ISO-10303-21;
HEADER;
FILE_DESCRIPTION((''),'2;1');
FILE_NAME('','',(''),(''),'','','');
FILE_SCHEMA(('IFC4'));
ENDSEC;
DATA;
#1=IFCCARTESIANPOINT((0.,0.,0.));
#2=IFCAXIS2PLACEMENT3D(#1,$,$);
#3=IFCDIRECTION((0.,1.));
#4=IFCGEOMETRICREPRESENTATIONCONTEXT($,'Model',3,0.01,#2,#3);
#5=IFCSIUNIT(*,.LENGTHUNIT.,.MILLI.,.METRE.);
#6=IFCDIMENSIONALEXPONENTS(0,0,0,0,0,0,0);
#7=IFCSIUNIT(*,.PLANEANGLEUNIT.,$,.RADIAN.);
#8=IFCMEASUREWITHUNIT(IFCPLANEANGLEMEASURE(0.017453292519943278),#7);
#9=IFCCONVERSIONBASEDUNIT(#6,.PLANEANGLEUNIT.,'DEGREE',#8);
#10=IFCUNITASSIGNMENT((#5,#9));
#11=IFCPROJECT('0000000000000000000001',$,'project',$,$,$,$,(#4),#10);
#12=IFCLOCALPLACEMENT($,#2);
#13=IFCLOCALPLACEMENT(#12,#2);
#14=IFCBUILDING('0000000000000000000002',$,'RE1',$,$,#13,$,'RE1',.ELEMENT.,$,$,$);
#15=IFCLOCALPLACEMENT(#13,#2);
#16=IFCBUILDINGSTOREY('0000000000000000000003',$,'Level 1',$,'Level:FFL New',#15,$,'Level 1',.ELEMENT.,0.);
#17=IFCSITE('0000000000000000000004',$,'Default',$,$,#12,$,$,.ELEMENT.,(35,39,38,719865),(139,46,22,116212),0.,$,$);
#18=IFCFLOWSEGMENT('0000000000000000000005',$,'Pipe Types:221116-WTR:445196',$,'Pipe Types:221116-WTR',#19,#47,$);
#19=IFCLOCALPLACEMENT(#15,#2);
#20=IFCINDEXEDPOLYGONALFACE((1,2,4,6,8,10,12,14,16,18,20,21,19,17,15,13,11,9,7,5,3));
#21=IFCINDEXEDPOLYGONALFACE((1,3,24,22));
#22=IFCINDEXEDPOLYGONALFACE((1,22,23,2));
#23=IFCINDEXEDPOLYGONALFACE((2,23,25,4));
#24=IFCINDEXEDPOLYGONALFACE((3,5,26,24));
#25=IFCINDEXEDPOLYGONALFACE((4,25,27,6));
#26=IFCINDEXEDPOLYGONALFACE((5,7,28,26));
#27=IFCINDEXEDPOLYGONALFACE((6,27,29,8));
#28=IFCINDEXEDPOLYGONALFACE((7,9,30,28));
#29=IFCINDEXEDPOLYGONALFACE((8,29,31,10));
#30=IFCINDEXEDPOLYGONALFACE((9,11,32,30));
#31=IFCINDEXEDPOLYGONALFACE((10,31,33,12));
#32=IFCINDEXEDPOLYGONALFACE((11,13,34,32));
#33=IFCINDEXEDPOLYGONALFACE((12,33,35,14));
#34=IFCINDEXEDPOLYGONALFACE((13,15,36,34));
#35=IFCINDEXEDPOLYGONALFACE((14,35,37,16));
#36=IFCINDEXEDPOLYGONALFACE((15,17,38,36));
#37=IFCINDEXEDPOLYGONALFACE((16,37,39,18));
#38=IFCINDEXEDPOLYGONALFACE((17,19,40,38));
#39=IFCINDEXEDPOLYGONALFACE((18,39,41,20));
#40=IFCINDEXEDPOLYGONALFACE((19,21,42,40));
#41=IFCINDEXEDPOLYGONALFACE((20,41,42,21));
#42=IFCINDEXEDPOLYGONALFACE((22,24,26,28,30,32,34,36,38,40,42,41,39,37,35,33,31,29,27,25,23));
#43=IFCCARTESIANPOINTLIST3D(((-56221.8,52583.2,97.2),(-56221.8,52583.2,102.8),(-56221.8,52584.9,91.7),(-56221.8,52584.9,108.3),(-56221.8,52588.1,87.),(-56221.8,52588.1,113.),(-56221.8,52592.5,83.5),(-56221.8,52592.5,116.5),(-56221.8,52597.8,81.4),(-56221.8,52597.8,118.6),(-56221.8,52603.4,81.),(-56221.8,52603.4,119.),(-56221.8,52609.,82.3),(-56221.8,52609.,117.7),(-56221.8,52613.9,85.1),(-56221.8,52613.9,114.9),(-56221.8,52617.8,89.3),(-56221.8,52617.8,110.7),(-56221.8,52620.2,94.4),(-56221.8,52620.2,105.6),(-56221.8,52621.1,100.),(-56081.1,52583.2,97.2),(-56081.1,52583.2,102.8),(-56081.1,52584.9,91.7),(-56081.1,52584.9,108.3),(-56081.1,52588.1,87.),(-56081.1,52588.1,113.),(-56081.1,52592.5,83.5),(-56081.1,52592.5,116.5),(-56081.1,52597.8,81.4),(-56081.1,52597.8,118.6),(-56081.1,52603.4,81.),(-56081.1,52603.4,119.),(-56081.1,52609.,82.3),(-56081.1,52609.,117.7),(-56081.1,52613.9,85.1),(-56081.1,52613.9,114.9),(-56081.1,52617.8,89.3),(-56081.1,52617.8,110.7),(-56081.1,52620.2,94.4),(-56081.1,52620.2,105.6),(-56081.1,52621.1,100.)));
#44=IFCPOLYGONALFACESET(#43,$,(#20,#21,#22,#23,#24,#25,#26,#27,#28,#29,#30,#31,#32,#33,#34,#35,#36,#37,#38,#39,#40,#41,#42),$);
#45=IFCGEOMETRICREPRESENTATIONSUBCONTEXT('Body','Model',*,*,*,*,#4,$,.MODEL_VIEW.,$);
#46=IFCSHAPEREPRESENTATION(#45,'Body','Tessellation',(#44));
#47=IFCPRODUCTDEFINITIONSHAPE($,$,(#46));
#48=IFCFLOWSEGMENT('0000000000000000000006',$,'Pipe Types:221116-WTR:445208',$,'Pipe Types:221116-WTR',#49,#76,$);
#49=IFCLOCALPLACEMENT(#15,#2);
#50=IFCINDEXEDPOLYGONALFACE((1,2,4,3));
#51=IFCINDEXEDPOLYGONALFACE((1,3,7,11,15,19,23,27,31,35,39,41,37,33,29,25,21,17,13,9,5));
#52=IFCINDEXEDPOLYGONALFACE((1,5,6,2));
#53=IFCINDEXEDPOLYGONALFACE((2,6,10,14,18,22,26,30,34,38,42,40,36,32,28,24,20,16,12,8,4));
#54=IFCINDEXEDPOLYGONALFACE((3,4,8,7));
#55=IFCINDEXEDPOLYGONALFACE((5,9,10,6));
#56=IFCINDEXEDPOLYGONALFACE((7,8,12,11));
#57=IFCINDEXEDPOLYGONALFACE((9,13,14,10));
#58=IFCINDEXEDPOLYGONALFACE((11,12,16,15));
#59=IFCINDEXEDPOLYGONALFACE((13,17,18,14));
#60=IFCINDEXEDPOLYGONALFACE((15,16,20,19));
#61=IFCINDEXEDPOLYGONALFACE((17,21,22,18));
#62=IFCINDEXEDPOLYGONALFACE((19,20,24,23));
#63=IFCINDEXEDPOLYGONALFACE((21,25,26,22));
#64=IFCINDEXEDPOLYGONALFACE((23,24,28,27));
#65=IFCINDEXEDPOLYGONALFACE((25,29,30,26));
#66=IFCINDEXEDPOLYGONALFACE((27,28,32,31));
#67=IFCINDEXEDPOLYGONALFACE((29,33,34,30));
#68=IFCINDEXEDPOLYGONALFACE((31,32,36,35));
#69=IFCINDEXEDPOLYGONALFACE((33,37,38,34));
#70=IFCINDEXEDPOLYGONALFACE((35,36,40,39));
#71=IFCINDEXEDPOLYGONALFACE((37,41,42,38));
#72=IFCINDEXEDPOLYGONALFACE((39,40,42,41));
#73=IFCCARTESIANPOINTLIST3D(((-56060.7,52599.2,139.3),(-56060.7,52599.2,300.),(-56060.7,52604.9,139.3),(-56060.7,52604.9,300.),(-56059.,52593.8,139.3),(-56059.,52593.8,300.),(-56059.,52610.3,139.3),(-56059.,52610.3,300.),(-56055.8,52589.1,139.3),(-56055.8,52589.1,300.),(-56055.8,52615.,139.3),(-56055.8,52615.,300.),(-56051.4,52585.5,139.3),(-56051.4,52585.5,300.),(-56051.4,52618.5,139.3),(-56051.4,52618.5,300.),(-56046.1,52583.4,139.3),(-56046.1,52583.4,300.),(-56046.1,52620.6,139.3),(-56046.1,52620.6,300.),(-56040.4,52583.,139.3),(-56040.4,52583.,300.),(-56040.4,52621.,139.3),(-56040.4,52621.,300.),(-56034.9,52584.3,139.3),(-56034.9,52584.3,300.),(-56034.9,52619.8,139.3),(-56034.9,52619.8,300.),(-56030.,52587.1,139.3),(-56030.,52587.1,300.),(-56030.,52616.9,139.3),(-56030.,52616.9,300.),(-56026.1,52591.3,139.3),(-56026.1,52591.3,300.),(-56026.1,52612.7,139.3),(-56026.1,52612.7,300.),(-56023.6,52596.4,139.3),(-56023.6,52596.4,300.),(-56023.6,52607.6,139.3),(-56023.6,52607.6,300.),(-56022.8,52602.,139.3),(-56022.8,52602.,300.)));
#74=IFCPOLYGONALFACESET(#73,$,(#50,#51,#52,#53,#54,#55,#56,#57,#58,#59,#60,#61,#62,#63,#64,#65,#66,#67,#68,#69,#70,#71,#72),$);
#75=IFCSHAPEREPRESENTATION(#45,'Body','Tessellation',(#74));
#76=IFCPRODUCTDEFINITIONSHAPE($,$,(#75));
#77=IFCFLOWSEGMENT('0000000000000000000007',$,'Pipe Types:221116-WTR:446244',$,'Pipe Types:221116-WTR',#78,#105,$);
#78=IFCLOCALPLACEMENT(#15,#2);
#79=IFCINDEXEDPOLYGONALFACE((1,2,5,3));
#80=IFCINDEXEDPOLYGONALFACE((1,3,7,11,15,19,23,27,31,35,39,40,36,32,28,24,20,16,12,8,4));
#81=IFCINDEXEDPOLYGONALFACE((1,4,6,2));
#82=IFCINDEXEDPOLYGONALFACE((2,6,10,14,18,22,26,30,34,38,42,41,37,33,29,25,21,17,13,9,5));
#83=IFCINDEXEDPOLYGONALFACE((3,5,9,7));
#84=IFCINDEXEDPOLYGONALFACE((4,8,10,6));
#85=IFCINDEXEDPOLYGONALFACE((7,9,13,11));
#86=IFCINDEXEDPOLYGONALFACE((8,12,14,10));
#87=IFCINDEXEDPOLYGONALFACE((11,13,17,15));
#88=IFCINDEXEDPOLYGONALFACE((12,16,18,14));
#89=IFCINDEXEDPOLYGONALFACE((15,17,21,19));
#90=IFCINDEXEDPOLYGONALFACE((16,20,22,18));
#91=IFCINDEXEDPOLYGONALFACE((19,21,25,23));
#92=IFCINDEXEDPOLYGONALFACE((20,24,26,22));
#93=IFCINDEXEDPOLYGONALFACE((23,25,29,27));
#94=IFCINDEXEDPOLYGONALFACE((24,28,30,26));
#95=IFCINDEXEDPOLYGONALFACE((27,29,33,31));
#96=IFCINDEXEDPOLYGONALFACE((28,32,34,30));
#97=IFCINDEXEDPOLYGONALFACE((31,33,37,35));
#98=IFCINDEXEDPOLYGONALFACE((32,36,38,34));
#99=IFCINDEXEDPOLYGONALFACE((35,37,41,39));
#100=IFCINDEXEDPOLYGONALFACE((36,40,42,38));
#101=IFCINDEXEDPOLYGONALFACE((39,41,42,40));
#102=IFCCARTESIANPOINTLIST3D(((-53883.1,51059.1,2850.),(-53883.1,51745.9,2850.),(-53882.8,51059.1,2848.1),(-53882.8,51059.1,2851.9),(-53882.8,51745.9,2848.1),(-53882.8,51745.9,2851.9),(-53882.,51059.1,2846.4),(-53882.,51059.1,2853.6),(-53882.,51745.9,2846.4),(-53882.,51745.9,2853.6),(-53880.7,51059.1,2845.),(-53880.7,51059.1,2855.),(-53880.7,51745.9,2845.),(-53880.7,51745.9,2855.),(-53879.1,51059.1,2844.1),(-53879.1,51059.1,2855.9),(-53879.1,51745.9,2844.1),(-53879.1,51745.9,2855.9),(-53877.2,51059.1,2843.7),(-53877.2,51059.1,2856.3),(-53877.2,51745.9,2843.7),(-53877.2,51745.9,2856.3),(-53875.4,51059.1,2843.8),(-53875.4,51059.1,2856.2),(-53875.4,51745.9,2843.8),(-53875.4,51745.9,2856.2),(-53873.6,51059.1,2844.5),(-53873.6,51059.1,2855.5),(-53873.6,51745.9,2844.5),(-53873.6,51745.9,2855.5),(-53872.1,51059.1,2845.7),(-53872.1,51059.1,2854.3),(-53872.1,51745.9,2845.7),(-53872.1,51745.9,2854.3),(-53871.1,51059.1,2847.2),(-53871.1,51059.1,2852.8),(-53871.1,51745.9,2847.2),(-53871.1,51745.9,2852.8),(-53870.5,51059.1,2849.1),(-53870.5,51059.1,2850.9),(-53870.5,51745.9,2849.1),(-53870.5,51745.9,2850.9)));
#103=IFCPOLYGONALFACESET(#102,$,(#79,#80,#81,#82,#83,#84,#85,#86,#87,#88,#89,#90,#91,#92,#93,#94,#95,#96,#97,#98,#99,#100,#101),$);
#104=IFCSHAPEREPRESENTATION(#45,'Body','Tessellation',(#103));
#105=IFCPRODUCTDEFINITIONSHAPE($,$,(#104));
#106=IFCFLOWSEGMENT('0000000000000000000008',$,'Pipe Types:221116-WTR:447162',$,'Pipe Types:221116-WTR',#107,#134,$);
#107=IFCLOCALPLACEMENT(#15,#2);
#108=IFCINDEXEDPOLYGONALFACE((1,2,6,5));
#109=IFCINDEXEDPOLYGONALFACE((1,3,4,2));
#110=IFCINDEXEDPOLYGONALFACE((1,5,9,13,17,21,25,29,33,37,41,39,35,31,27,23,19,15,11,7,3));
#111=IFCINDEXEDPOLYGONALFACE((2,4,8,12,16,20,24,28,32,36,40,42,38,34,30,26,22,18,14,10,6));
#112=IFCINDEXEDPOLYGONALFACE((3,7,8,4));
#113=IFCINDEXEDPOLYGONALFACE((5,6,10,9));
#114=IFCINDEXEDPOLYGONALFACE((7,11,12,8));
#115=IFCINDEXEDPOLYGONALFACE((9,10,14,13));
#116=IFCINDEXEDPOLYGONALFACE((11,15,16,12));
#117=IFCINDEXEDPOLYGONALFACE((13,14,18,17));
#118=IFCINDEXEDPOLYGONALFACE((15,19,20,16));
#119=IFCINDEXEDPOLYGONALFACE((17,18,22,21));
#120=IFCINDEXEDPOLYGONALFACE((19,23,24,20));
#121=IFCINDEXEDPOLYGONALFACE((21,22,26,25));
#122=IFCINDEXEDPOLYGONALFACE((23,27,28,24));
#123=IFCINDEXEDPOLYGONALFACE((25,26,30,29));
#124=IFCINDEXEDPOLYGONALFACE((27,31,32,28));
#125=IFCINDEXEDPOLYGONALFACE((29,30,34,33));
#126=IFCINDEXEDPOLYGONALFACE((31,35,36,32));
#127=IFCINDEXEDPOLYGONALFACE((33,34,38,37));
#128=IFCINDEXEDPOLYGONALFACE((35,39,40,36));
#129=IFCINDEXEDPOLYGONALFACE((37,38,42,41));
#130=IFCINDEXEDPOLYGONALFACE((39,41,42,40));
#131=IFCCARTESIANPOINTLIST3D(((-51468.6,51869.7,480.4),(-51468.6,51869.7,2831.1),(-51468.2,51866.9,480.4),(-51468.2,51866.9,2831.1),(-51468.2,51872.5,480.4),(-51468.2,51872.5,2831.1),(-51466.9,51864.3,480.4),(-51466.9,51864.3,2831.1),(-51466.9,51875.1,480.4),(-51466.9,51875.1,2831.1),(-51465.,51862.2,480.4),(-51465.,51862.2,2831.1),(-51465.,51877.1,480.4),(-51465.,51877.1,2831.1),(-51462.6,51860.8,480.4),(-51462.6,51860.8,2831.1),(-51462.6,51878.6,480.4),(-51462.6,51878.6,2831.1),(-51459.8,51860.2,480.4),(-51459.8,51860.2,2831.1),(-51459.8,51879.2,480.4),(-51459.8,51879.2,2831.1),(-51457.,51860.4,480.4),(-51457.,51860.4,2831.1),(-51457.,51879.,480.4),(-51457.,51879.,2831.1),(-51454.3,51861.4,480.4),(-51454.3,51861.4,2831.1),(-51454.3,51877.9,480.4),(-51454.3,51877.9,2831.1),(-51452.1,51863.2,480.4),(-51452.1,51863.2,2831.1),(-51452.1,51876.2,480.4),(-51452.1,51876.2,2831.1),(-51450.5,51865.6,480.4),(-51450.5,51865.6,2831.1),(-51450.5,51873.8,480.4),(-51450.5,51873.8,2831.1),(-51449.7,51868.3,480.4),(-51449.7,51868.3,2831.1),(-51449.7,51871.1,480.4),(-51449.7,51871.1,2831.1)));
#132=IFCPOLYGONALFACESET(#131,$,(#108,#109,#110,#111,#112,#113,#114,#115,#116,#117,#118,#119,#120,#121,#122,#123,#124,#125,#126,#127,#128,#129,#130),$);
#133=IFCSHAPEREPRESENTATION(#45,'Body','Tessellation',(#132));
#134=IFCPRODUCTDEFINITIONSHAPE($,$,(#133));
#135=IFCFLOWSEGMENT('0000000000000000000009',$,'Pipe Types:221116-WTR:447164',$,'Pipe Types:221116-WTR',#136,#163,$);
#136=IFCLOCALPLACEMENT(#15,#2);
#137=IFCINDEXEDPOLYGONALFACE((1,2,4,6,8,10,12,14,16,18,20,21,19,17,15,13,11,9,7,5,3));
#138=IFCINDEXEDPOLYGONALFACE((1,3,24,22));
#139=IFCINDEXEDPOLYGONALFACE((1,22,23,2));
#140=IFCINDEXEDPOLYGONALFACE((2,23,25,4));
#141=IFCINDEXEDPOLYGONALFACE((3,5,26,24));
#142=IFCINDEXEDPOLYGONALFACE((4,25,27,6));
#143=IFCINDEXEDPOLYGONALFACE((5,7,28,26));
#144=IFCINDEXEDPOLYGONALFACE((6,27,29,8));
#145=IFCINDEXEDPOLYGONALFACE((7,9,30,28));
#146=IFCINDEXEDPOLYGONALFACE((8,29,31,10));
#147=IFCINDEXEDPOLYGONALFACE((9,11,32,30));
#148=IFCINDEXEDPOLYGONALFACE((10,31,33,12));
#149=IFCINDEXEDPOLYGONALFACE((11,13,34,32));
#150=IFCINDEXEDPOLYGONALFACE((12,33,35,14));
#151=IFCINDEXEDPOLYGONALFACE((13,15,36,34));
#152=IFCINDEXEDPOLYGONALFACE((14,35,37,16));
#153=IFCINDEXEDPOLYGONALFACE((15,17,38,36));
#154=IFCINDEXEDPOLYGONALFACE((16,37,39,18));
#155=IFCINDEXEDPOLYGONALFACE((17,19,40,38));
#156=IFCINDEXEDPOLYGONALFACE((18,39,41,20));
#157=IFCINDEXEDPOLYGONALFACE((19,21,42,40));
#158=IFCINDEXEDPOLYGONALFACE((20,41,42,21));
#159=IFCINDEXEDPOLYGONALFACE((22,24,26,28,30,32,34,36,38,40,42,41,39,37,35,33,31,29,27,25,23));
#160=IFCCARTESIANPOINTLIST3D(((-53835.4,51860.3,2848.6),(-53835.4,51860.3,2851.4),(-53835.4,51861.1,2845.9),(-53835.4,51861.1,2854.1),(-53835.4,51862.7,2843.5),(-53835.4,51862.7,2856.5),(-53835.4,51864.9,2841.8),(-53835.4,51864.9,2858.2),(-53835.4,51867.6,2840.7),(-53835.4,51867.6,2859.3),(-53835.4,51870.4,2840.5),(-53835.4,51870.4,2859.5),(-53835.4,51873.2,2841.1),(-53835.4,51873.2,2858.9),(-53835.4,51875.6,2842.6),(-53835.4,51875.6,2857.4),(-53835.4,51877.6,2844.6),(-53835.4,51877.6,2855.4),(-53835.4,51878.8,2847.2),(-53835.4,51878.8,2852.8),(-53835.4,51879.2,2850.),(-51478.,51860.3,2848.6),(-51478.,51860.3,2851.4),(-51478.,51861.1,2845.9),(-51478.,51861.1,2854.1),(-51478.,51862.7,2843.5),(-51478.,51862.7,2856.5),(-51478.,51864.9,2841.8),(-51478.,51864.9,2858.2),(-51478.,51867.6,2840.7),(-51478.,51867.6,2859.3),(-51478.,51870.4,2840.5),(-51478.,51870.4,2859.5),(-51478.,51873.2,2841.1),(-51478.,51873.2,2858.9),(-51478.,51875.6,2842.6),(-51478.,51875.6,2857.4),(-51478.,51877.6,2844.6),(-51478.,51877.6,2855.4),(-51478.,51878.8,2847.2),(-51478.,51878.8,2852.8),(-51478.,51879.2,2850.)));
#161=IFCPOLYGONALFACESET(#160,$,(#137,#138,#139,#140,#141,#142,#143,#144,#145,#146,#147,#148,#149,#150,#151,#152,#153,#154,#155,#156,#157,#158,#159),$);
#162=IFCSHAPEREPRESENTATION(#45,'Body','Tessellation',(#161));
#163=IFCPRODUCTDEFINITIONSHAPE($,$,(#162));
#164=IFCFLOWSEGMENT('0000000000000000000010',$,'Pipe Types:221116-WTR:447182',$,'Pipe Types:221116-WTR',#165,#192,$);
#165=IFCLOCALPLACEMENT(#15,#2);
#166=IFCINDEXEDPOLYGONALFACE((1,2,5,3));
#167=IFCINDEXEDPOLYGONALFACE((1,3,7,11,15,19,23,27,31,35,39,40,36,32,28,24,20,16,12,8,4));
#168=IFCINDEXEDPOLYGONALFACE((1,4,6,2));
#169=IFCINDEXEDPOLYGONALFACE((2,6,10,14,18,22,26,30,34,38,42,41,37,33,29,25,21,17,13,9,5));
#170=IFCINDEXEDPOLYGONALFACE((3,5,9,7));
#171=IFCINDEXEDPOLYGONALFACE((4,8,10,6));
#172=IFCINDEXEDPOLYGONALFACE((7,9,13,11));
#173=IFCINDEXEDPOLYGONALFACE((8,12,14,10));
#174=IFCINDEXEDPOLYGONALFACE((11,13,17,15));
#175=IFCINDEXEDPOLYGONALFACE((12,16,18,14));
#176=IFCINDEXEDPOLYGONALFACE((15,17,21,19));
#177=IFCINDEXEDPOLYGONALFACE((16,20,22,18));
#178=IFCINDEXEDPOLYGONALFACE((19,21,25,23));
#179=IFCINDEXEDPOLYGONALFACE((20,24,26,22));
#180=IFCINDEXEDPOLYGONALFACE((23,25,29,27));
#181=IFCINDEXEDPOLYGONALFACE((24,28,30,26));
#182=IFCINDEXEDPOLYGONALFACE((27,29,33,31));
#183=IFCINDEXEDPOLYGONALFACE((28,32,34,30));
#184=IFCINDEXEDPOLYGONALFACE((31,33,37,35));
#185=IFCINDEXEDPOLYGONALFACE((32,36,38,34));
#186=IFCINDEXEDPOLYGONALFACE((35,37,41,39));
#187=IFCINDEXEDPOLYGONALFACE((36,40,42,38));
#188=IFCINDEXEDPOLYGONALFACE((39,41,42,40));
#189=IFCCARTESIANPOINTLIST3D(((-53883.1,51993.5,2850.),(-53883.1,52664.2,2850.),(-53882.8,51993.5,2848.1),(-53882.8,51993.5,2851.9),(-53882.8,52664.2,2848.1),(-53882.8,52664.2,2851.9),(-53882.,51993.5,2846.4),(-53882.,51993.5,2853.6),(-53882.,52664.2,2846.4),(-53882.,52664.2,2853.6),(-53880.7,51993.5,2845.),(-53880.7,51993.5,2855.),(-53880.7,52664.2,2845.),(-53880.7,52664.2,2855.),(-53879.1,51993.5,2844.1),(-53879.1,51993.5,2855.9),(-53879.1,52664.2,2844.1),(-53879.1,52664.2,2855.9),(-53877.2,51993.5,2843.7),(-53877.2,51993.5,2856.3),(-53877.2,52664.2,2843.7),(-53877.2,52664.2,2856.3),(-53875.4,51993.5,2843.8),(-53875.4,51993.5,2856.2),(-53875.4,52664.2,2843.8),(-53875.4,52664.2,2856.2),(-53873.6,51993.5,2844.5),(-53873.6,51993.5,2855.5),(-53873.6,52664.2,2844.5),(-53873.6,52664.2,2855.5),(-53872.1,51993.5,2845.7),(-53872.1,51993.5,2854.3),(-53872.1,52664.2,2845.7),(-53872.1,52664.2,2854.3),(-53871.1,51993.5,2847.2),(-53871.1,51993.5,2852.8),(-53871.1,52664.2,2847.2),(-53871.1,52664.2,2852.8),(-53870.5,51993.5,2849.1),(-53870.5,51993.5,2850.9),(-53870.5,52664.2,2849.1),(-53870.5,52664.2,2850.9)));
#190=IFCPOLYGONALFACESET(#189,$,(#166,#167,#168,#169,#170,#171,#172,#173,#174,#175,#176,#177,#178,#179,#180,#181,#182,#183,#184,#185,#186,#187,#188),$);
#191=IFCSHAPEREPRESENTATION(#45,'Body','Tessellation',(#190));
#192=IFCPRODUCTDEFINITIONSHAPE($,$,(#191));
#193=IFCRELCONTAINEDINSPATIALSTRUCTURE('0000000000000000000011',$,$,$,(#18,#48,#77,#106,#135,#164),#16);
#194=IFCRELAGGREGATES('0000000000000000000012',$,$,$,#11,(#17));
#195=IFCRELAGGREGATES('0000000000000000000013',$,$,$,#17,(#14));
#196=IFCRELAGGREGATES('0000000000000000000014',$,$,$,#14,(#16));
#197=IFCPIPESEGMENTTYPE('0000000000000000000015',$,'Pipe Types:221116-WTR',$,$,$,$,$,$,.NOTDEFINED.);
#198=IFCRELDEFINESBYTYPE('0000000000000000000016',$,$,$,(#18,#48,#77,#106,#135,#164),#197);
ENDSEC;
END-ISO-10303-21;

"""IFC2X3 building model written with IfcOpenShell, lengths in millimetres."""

from ifc_helpers import new_model, entity, si_unit, converted_unit, direction, frame, frame_2d, origin, origin_2d_with_axis, place, context, subcontext, project, spatial, circle, extrude, type_object, element, save


model = new_model("IFC2X3")

# Units and contexts
model_context = context("Model", 3, precision=0.01, world=origin(), true_north=direction((0.0, 1.0)))
body_context = subcontext(model_context, "Body", "Model", "MODEL_VIEW")
ifc_project = project(units=[si_unit("LENGTHUNIT", "METRE", prefix="MILLI"), converted_unit("PLANEANGLEUNIT", "DEGREE", entity("IfcPlaneAngleMeasure", 0.017453292519943278), si_unit("PLANEANGLEUNIT", "RADIAN"), dimensions=[0, 0, 0, 0, 0, 0, 0])], contexts=[model_context])

# Site, building, storey
site_placement = place(None, origin())
site = spatial("IfcSite", under=ifc_project, at=site_placement, Name="Default", CompositionType="ELEMENT", RefLatitude=(35, 39, 38, 719865), RefLongitude=(139, 46, 22, 116212), RefElevation=0.0)
building_placement = place(site_placement, origin())
building = spatial("IfcBuilding", under=site, at=building_placement, Name="RE1", LongName="RE1", CompositionType="ELEMENT")
storey_placement = place(building_placement, origin())
storey = spatial("IfcBuildingStorey", under=building, at=storey_placement, Name="Level 1", ObjectType="Level:FFL New", LongName="Level 1", CompositionType="ELEMENT", Elevation=0.0)

# Flow segments
pipe_segment_type_1 = type_object("IfcPipeSegmentType", Name="Pipe Types:221116-WTR", PredefinedType="NOTDEFINED")
flow_segment_1_placement = place(storey_placement, origin())
element("IfcFlowSegment", 1, at=flow_segment_1_placement, inside=storey, type_object=pipe_segment_type_1, Name="Pipe Types:221116-WTR:445196", ObjectType="Pipe Types:221116-WTR", context=body_context, shape_type="SweptSolid", body=[
    extrude(circle(Radius=19.1, at=frame_2d((0.0, 0.0), x_axis=(1.0, 0.0))), frame((-56221.8, 52602.0, 100.0), z_axis=(1.0, 0.0, 0.0), x_axis=(0.0, 1.0, 0.0)), (0.0, 0.0, 1.0), 140.7),
])
flow_segment_2_placement = place(storey_placement, origin())
element("IfcFlowSegment", 2, at=flow_segment_2_placement, inside=storey, type_object=pipe_segment_type_1, Name="Pipe Types:221116-WTR:445208", ObjectType="Pipe Types:221116-WTR", context=body_context, shape_type="SweptSolid", body=[
    extrude(circle(Radius=19.1, at=origin_2d_with_axis()), frame((-56041.8, 52602.0, 139.3)), (0.0, 0.0, 1.0), 160.7),
])
flow_segment_3_placement = place(storey_placement, origin())
element("IfcFlowSegment", 3, at=flow_segment_3_placement, inside=storey, type_object=pipe_segment_type_1, Name="Pipe Types:221116-WTR:446244", ObjectType="Pipe Types:221116-WTR", context=body_context, shape_type="SweptSolid", body=[
    extrude(circle(Radius=6.3, at=frame_2d((0.0, 0.0), x_axis=(1.0, 0.0))), frame((-53876.8, 51059.1, 2850.0), z_axis=(0.0, 1.0, 0.0), x_axis=(-1.0, 0.0, 0.0)), (0.0, 0.0, 1.0), 686.7),
])
flow_segment_4_placement = place(storey_placement, origin())
element("IfcFlowSegment", 4, at=flow_segment_4_placement, inside=storey, type_object=pipe_segment_type_1, Name="Pipe Types:221116-WTR:447162", ObjectType="Pipe Types:221116-WTR", context=body_context, shape_type="SweptSolid", body=[
    extrude(circle(Radius=9.5, at=origin_2d_with_axis()), frame((-51459.1, 51869.7, 480.4), z_axis=(0.0, 0.0, 1.0), x_axis=(-1.0, 0.0, 0.0)), (0.0, 0.0, 1.0), 2350.7),
])
flow_segment_5_placement = place(storey_placement, origin())
element("IfcFlowSegment", 5, at=flow_segment_5_placement, inside=storey, type_object=pipe_segment_type_1, Name="Pipe Types:221116-WTR:447164", ObjectType="Pipe Types:221116-WTR", context=body_context, shape_type="SweptSolid", body=[
    extrude(circle(Radius=9.5, at=origin_2d_with_axis()), frame((-53835.4, 51869.7, 2850.0), z_axis=(1.0, 0.0, 0.0), x_axis=(0.0, 1.0, 0.0)), (0.0, 0.0, 1.0), 2357.4),
])
flow_segment_6_placement = place(storey_placement, origin())
element("IfcFlowSegment", 6, at=flow_segment_6_placement, inside=storey, type_object=pipe_segment_type_1, Name="Pipe Types:221116-WTR:447182", ObjectType="Pipe Types:221116-WTR", context=body_context, shape_type="SweptSolid", body=[
    extrude(circle(Radius=6.3, at=frame_2d((0.0, 0.0), x_axis=(1.0, 0.0))), frame((-53876.8, 51993.5, 2850.0), z_axis=(0.0, 1.0, 0.0), x_axis=(-1.0, 0.0, 0.0)), (0.0, 0.0, 1.0), 670.7),
])

save(model, "model.ifc")
